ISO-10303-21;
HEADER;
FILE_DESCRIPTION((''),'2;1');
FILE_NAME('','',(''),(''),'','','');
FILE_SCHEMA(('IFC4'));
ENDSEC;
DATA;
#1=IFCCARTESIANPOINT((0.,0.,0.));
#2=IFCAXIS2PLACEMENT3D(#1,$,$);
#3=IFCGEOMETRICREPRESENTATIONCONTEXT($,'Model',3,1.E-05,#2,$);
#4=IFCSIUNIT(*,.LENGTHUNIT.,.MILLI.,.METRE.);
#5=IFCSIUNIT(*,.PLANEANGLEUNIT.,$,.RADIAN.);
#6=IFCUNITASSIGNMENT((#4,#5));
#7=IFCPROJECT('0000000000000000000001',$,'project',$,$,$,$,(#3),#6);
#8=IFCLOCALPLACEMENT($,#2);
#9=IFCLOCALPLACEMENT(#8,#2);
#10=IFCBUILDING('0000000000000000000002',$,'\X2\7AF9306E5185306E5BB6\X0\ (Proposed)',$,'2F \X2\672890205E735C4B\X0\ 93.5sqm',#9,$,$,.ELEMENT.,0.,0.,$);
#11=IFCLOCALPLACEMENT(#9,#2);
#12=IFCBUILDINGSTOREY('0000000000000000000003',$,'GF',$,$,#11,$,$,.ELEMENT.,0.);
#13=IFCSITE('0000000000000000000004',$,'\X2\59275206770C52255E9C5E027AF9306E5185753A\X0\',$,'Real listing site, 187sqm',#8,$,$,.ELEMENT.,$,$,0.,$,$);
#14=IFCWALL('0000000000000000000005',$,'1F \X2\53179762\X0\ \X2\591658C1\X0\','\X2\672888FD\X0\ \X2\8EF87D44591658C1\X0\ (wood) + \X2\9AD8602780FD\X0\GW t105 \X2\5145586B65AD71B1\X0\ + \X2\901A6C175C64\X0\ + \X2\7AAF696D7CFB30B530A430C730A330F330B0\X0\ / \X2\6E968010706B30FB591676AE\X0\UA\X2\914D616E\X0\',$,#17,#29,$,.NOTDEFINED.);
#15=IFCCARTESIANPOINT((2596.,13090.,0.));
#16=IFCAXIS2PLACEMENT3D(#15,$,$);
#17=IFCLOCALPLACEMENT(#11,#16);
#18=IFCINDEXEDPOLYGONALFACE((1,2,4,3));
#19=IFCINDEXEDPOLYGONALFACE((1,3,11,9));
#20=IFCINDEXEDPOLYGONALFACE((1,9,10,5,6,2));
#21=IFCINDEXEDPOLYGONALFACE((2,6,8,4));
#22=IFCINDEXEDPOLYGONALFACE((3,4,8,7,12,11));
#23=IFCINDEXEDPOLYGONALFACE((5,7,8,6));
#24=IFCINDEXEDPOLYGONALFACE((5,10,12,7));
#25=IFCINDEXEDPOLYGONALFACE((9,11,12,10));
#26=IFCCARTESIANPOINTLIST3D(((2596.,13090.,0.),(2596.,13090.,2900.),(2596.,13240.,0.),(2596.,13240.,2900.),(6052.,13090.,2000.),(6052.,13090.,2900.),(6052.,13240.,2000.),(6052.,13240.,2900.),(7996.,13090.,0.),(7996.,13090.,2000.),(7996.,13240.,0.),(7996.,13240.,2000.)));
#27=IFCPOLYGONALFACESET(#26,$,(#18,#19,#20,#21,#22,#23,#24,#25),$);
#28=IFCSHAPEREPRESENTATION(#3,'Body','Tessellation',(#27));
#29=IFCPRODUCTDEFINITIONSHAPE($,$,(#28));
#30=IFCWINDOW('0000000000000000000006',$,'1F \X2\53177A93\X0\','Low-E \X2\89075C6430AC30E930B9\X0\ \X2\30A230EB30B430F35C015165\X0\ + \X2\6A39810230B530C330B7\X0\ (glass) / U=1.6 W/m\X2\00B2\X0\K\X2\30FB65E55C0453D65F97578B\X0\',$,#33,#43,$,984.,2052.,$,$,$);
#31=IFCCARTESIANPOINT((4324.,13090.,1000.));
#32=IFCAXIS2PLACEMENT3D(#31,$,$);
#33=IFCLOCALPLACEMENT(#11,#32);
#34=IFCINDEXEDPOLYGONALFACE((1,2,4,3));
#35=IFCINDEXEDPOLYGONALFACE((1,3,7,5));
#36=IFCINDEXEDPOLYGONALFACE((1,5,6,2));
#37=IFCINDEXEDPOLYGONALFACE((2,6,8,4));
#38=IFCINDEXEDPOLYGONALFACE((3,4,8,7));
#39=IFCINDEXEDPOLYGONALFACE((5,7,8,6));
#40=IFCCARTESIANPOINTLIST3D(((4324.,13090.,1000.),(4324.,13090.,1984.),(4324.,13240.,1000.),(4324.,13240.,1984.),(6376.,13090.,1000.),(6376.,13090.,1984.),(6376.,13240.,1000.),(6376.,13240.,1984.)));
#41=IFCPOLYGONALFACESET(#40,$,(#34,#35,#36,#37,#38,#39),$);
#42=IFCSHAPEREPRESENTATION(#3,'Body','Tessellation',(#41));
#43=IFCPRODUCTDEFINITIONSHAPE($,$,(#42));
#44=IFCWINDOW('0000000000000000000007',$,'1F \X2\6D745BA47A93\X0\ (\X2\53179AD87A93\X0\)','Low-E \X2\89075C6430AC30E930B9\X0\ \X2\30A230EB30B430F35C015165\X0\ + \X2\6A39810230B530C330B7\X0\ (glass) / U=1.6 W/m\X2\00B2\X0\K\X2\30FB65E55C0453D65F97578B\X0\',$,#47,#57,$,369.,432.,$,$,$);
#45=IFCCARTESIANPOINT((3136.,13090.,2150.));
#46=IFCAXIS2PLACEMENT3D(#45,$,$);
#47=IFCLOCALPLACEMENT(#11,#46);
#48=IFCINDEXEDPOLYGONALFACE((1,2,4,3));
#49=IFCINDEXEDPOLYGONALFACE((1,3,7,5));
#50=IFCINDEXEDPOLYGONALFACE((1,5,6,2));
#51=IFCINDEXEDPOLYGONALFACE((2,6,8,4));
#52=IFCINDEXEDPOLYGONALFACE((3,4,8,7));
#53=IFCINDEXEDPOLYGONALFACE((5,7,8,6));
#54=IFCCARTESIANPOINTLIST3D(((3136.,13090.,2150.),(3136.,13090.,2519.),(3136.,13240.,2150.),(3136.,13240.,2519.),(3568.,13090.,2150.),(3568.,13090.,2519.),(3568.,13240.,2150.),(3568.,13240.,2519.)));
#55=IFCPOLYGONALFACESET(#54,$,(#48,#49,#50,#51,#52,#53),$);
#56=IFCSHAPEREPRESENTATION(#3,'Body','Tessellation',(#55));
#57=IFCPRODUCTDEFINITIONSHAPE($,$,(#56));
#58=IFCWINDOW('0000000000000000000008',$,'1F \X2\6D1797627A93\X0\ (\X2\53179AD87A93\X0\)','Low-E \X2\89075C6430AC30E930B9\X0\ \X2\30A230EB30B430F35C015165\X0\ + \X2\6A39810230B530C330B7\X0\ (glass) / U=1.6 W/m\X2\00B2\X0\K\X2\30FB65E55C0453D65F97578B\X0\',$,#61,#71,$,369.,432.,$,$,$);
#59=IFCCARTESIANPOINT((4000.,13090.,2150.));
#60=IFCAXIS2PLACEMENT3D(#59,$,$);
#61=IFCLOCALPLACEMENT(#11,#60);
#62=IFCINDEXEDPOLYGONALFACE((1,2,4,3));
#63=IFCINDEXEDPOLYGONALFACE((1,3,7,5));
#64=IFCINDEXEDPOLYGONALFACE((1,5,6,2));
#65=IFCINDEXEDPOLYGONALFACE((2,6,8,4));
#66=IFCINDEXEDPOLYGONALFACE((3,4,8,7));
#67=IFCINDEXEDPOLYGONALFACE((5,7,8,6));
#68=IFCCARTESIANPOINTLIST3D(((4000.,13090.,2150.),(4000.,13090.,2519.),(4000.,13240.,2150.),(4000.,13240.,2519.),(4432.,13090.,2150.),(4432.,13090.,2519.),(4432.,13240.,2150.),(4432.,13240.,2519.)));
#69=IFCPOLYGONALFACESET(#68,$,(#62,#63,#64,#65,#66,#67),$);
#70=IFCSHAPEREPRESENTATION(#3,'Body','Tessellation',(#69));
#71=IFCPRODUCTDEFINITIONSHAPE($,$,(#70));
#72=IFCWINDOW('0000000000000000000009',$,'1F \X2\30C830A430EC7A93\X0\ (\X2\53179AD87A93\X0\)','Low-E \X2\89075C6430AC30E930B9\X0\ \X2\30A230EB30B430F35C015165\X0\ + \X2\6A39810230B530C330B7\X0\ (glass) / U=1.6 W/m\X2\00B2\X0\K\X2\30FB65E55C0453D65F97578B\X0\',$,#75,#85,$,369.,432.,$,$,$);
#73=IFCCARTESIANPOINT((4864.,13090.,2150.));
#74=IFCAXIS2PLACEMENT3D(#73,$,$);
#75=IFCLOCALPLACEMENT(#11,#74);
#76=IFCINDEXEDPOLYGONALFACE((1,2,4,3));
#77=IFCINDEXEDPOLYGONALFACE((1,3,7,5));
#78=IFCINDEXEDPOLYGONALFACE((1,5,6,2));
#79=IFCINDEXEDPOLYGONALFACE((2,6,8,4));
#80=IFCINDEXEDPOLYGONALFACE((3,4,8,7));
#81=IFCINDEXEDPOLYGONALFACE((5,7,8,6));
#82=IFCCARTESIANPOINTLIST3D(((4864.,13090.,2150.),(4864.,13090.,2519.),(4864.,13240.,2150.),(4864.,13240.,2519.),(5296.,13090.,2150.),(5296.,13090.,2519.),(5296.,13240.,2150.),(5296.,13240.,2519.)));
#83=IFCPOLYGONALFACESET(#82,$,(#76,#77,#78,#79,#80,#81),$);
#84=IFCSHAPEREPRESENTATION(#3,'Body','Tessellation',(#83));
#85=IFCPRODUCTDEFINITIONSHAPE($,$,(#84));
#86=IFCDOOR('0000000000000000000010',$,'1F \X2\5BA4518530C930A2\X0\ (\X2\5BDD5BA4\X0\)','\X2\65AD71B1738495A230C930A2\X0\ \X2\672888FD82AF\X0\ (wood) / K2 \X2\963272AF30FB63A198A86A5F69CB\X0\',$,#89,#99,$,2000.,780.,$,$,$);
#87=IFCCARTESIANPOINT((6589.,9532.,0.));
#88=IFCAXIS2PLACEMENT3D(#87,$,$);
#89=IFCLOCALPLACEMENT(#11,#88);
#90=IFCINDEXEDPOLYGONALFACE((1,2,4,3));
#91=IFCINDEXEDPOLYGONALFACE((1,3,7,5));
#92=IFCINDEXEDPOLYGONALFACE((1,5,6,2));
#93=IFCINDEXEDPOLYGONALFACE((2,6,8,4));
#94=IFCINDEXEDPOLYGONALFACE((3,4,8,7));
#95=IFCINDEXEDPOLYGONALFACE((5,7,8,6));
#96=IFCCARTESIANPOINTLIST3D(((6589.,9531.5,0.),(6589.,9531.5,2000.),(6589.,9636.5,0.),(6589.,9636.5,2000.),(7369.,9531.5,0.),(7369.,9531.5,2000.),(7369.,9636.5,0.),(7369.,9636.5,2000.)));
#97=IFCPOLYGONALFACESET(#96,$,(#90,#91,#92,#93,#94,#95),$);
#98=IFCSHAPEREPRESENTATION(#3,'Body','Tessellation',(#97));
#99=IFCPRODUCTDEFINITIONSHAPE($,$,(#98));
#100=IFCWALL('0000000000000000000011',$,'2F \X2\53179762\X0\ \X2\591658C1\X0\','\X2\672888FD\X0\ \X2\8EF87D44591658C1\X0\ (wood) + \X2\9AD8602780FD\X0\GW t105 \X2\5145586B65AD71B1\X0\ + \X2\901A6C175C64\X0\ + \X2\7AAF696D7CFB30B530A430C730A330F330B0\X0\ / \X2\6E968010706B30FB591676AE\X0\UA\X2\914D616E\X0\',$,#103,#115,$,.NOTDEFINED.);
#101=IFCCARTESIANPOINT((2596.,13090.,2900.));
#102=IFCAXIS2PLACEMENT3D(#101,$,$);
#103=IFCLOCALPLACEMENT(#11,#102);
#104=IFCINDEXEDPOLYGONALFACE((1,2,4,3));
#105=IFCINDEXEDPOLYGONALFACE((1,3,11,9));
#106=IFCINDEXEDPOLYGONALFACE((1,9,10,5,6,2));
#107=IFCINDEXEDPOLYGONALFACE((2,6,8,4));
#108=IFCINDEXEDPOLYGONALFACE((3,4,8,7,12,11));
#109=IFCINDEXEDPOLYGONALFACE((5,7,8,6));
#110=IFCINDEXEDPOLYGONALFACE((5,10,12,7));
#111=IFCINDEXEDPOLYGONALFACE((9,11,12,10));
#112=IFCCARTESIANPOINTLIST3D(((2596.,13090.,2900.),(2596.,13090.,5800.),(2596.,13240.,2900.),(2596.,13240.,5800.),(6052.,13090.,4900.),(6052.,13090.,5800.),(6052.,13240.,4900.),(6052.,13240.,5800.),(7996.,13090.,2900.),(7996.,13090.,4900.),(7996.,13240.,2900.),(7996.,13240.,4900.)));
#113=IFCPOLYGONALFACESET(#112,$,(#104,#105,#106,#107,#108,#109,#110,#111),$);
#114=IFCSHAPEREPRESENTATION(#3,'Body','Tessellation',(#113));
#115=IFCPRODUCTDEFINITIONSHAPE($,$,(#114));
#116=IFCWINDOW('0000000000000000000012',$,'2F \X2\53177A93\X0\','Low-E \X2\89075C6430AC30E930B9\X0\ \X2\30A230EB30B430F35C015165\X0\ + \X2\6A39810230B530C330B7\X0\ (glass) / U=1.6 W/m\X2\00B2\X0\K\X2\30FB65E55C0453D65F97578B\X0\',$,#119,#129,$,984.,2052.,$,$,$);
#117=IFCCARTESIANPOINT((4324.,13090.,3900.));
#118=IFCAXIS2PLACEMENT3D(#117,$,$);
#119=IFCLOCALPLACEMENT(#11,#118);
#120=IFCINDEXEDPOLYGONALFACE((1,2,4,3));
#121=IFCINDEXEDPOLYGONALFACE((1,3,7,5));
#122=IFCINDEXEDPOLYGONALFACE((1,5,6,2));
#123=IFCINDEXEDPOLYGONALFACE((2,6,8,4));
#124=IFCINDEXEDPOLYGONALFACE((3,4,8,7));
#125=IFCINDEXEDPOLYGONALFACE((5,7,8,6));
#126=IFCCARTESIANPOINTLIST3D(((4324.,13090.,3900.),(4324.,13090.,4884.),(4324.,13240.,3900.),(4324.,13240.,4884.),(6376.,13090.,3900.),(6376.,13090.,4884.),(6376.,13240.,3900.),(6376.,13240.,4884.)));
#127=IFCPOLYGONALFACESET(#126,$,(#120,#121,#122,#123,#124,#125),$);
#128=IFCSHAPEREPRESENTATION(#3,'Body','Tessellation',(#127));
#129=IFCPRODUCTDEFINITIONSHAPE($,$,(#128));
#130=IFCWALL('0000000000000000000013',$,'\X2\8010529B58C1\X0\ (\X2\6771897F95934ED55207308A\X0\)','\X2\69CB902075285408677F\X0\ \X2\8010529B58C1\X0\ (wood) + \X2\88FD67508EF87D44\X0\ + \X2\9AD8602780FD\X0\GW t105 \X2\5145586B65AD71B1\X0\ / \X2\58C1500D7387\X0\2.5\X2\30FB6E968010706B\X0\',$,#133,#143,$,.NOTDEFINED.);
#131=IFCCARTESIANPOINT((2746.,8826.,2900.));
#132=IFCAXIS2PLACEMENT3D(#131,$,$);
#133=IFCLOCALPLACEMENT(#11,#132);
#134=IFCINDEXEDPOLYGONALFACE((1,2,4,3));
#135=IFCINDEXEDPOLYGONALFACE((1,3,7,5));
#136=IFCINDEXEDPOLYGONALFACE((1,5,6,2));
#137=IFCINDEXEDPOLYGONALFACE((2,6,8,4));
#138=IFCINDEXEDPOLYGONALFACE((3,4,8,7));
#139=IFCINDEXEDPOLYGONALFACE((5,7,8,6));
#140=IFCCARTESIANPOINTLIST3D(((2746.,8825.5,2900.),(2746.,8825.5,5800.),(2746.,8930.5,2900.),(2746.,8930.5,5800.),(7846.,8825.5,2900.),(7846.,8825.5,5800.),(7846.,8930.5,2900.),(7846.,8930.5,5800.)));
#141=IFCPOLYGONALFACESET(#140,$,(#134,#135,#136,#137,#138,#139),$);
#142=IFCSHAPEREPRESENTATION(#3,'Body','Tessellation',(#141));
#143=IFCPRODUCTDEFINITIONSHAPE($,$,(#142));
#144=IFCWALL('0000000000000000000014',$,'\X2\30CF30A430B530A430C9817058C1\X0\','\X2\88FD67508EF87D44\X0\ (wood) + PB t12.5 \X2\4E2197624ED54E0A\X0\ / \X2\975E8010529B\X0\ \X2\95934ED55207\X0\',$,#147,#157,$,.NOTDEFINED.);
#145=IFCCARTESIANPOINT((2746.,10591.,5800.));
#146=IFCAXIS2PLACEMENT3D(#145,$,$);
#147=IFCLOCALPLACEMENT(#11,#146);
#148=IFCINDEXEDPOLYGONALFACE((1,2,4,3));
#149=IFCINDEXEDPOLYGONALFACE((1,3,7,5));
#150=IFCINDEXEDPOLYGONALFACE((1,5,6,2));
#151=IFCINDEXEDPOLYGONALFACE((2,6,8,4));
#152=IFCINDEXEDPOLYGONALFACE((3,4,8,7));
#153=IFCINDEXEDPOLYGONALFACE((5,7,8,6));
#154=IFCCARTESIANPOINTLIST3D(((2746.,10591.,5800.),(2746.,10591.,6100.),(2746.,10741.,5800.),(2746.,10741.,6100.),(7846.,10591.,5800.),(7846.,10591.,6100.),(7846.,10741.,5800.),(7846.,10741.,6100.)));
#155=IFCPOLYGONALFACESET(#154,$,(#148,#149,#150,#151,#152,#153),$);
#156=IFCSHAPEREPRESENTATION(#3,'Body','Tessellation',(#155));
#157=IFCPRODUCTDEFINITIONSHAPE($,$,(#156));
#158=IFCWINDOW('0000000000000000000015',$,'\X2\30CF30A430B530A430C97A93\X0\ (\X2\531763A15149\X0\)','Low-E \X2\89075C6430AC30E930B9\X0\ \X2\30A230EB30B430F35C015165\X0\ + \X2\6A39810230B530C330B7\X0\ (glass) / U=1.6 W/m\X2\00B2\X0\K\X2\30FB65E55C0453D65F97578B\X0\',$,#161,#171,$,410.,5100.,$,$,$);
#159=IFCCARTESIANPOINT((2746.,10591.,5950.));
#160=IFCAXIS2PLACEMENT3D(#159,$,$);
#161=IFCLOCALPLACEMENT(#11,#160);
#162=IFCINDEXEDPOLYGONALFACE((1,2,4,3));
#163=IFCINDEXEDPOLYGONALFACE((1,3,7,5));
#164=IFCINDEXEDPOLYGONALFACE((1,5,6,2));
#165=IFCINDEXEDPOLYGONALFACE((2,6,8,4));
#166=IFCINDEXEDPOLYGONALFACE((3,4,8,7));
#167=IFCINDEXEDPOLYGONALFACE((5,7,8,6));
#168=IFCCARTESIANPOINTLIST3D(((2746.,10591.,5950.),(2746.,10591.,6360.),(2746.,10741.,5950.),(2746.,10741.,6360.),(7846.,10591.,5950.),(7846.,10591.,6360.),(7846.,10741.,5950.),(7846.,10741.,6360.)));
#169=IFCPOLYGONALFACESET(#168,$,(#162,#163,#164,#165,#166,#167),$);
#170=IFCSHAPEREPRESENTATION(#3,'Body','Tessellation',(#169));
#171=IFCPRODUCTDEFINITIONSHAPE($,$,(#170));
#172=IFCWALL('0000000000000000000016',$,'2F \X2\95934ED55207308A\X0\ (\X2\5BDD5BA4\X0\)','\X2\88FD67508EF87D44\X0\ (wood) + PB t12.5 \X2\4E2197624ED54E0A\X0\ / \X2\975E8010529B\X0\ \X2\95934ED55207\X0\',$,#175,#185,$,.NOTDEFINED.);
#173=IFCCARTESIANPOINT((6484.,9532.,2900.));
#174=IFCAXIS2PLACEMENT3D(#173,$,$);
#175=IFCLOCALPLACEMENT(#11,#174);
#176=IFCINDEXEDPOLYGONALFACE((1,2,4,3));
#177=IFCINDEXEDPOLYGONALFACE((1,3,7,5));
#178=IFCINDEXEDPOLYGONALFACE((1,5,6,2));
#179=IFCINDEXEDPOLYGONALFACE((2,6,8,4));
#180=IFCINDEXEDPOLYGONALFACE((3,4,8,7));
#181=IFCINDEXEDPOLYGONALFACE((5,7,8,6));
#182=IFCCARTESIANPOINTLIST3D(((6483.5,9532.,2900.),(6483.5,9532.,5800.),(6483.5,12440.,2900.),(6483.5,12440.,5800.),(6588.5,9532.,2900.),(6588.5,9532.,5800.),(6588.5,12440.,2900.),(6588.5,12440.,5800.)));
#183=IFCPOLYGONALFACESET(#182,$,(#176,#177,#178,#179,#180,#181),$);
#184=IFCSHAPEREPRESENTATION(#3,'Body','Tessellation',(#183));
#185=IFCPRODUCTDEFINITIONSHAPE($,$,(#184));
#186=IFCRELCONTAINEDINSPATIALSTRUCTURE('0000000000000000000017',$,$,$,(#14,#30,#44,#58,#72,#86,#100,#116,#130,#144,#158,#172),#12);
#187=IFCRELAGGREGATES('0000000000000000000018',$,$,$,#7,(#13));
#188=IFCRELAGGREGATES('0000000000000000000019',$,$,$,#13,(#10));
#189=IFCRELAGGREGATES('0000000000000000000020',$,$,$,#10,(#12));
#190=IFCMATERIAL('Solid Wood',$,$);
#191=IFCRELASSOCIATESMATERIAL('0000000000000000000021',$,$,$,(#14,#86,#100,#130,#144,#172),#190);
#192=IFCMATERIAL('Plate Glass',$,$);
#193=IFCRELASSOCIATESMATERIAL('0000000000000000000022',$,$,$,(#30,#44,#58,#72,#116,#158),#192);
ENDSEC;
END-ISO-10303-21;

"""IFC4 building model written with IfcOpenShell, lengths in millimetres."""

from ifc_helpers import new_model, si_unit, frame, frame_2d, origin, place, context, project, spatial, rectangle, extrude, material, element, fill, save


model = new_model("IFC4")

# Units and contexts
model_context = context("Model", 3, precision=1e-05, world=origin())
ifc_project = project(units=[si_unit("LENGTHUNIT", "METRE", prefix="MILLI"), si_unit("PLANEANGLEUNIT", "RADIAN")], contexts=[model_context])

# Site, building, storey
site_placement = place(None, origin())
site = spatial("IfcSite", under=ifc_project, at=site_placement, Name="大分県別府市竹の内町", ObjectType="Real listing site, 187sqm", CompositionType="ELEMENT", RefElevation=0.0)
building_placement = place(site_placement, origin())
building = spatial("IfcBuilding", under=site, at=building_placement, Name="竹の内の家 (Proposed)", ObjectType="2F 木造平屋 93.5sqm", CompositionType="ELEMENT", ElevationOfRefHeight=0.0, ElevationOfTerrain=0.0)
storey_placement = place(building_placement, origin())
storey = spatial("IfcBuildingStorey", under=building, at=storey_placement, Name="GF", CompositionType="ELEMENT", Elevation=0.0)

# Wall, openings, windows
ifc_material_1 = material(Name="Solid Wood")
wall_1_placement = place(storey_placement, frame((2596.0, 13090.0, 0.0)))
wall_1 = element("IfcWall", 1, at=wall_1_placement, inside=storey, material=ifc_material_1, Name="1F 北面 外壁", Description="木製 軸組外壁 (wood) + 高性能GW t105 充填断熱 + 通気層 + 窯業系サイディング / 準耐火・外皮UA配慮", PredefinedType="NOTDEFINED", context=model_context, shape_type="SweptSolid", body=[
    extrude(rectangle(XDim=5400.0, YDim=150.0, at=frame_2d((2700.0, 75.0))), frame((2596.0, 13090.0, 0.0)), (0.0, 0.0, 1.0), 2900.0),
])
opening_1_placement = place(storey_placement, frame((4324.0, 13090.0, 1000.0)))
opening_1 = element("IfcOpeningElement", 2, at=opening_1_placement, cuts=wall_1, PredefinedType="NOTDEFINED", context=model_context, shape_type="SweptSolid", body=[
    extrude(rectangle(XDim=2052.0, YDim=150.0, at=frame_2d((1026.0, 75.0))), frame((4324.0, 13090.0, 1000.0)), (0.0, 0.0, 1.0), 984.0),
])
opening_2_placement = place(storey_placement, frame((3136.0, 13090.0, 2150.0)))
opening_2 = element("IfcOpeningElement", 3, at=opening_2_placement, cuts=wall_1, PredefinedType="NOTDEFINED", context=model_context, shape_type="SweptSolid", body=[
    extrude(rectangle(XDim=432.0, YDim=150.0, at=frame_2d((216.0, 75.0))), frame((3136.0, 13090.0, 2150.0)), (0.0, 0.0, 1.0), 369.0),
])
opening_3_placement = place(storey_placement, frame((4000.0, 13090.0, 2150.0)))
opening_3 = element("IfcOpeningElement", 4, at=opening_3_placement, cuts=wall_1, PredefinedType="NOTDEFINED", context=model_context, shape_type="SweptSolid", body=[
    extrude(rectangle(XDim=432.0, YDim=150.0, at=frame_2d((216.0, 75.0))), frame((4000.0, 13090.0, 2150.0)), (0.0, 0.0, 1.0), 369.0),
])
opening_4_placement = place(storey_placement, frame((4864.0, 13090.0, 2150.0)))
opening_4 = element("IfcOpeningElement", 5, at=opening_4_placement, cuts=wall_1, PredefinedType="NOTDEFINED", context=model_context, shape_type="SweptSolid", body=[
    extrude(rectangle(XDim=432.0, YDim=150.0, at=frame_2d((216.0, 75.0))), frame((4864.0, 13090.0, 2150.0)), (0.0, 0.0, 1.0), 369.0),
])
ifc_material_2 = material(Name="Plate Glass")
window_1_placement = place(storey_placement, frame((4324.0, 13090.0, 1000.0)))
window_1 = element("IfcWindow", 6, at=window_1_placement, inside=storey, material=ifc_material_2, Name="1F 北窓", Description="Low-E 複層ガラス アルゴン封入 + 樹脂サッシ (glass) / U=1.6 W/m²K・日射取得型", OverallHeight=984.0, OverallWidth=2052.0, context=model_context, shape_type="SweptSolid", body=[
    extrude(rectangle(XDim=2052.0, YDim=150.0, at=frame_2d((1026.0, 75.0))), frame((4324.0, 13090.0, 1000.0)), (0.0, 0.0, 1.0), 984.0),
])
fill(opening_1, window_1)
window_2_placement = place(storey_placement, frame((3136.0, 13090.0, 2150.0)))
window_2 = element("IfcWindow", 7, at=window_2_placement, inside=storey, material=ifc_material_2, Name="1F 浴室窓 (北高窓)", Description="Low-E 複層ガラス アルゴン封入 + 樹脂サッシ (glass) / U=1.6 W/m²K・日射取得型", OverallHeight=369.0, OverallWidth=432.0, context=model_context, shape_type="SweptSolid", body=[
    extrude(rectangle(XDim=432.0, YDim=150.0, at=frame_2d((216.0, 75.0))), frame((3136.0, 13090.0, 2150.0)), (0.0, 0.0, 1.0), 369.0),
])
fill(opening_2, window_2)
window_3_placement = place(storey_placement, frame((4000.0, 13090.0, 2150.0)))
window_3 = element("IfcWindow", 8, at=window_3_placement, inside=storey, material=ifc_material_2, Name="1F 洗面窓 (北高窓)", Description="Low-E 複層ガラス アルゴン封入 + 樹脂サッシ (glass) / U=1.6 W/m²K・日射取得型", OverallHeight=369.0, OverallWidth=432.0, context=model_context, shape_type="SweptSolid", body=[
    extrude(rectangle(XDim=432.0, YDim=150.0, at=frame_2d((216.0, 75.0))), frame((4000.0, 13090.0, 2150.0)), (0.0, 0.0, 1.0), 369.0),
])
fill(opening_3, window_3)
window_4_placement = place(storey_placement, frame((4864.0, 13090.0, 2150.0)))
window_4 = element("IfcWindow", 9, at=window_4_placement, inside=storey, material=ifc_material_2, Name="1F トイレ窓 (北高窓)", Description="Low-E 複層ガラス アルゴン封入 + 樹脂サッシ (glass) / U=1.6 W/m²K・日射取得型", OverallHeight=369.0, OverallWidth=432.0, context=model_context, shape_type="SweptSolid", body=[
    extrude(rectangle(XDim=432.0, YDim=150.0, at=frame_2d((216.0, 75.0))), frame((4864.0, 13090.0, 2150.0)), (0.0, 0.0, 1.0), 369.0),
])
fill(opening_4, window_4)

# Door
door_1_placement = place(storey_placement, frame((6589.0, 9532.0, 0.0)))
element("IfcDoor", 10, at=door_1_placement, inside=storey, material=ifc_material_1, Name="1F 室内ドア (寝室)", Description="断熱玄関ドア 木製芯 (wood) / K2 防犯・採風機構", OverallHeight=2000.0, OverallWidth=780.0, context=model_context, shape_type="SweptSolid", body=[
    extrude(rectangle(XDim=780.0, YDim=105.0, at=frame_2d((390.0, 52.0))), frame((6589.0, 9532.0, 0.0)), (0.0, 0.0, 1.0), 2000.0),
])

# Wall, opening, window
wall_2_placement = place(storey_placement, frame((2596.0, 13090.0, 2900.0)))
wall_2 = element("IfcWall", 11, at=wall_2_placement, inside=storey, material=ifc_material_1, Name="2F 北面 外壁", Description="木製 軸組外壁 (wood) + 高性能GW t105 充填断熱 + 通気層 + 窯業系サイディング / 準耐火・外皮UA配慮", PredefinedType="NOTDEFINED", context=model_context, shape_type="SweptSolid", body=[
    extrude(rectangle(XDim=5400.0, YDim=150.0, at=frame_2d((2700.0, 75.0))), frame((2596.0, 13090.0, 2900.0)), (0.0, 0.0, 1.0), 2900.0),
])
opening_5_placement = place(storey_placement, frame((4324.0, 13090.0, 3900.0)))
opening_5 = element("IfcOpeningElement", 12, at=opening_5_placement, cuts=wall_2, PredefinedType="NOTDEFINED", context=model_context, shape_type="SweptSolid", body=[
    extrude(rectangle(XDim=2052.0, YDim=150.0, at=frame_2d((1026.0, 75.0))), frame((4324.0, 13090.0, 3900.0)), (0.0, 0.0, 1.0), 984.0),
])
window_5_placement = place(storey_placement, frame((4324.0, 13090.0, 3900.0)))
window_5 = element("IfcWindow", 13, at=window_5_placement, inside=storey, material=ifc_material_2, Name="2F 北窓", Description="Low-E 複層ガラス アルゴン封入 + 樹脂サッシ (glass) / U=1.6 W/m²K・日射取得型", OverallHeight=984.0, OverallWidth=2052.0, context=model_context, shape_type="SweptSolid", body=[
    extrude(rectangle(XDim=2052.0, YDim=150.0, at=frame_2d((1026.0, 75.0))), frame((4324.0, 13090.0, 3900.0)), (0.0, 0.0, 1.0), 984.0),
])
fill(opening_5, window_5)

# Wall
wall_3_placement = place(storey_placement, frame((2746.0, 8826.0, 2900.0)))
element("IfcWall", 14, at=wall_3_placement, inside=storey, material=ifc_material_1, Name="耐力壁 (東西間仕切り)", Description="構造用合板 耐力壁 (wood) + 製材軸組 + 高性能GW t105 充填断熱 / 壁倍率2.5・準耐火", PredefinedType="NOTDEFINED", context=model_context, shape_type="SweptSolid", body=[
    extrude(rectangle(XDim=5100.0, YDim=105.0, at=frame_2d((2550.0, 52.0))), frame((2746.0, 8826.0, 2900.0)), (0.0, 0.0, 1.0), 2900.0),
])

# Wall, opening, window
wall_4_placement = place(storey_placement, frame((2746.0, 10591.0, 5800.0)))
wall_4 = element("IfcWall", 15, at=wall_4_placement, inside=storey, material=ifc_material_1, Name="ハイサイド腰壁", Description="製材軸組 (wood) + PB t12.5 両面仕上 / 非耐力 間仕切", PredefinedType="NOTDEFINED", context=model_context, shape_type="SweptSolid", body=[
    extrude(rectangle(XDim=5100.0, YDim=150.0, at=frame_2d((2550.0, 75.0))), frame((2746.0, 10591.0, 5800.0)), (0.0, 0.0, 1.0), 700.0),
])
opening_6_placement = place(storey_placement, frame((2746.0, 10591.0, 5950.0)))
opening_6 = element("IfcOpeningElement", 16, at=opening_6_placement, cuts=wall_4, PredefinedType="NOTDEFINED", context=model_context, shape_type="SweptSolid", body=[
    extrude(rectangle(XDim=5100.0, YDim=150.0, at=frame_2d((2550.0, 75.0))), frame((2746.0, 10591.0, 5950.0)), (0.0, 0.0, 1.0), 410.0),
])
window_6_placement = place(storey_placement, frame((2746.0, 10591.0, 5950.0)))
window_6 = element("IfcWindow", 17, at=window_6_placement, inside=storey, material=ifc_material_2, Name="ハイサイド窓 (北採光)", Description="Low-E 複層ガラス アルゴン封入 + 樹脂サッシ (glass) / U=1.6 W/m²K・日射取得型", OverallHeight=410.0, OverallWidth=5100.0, context=model_context, shape_type="SweptSolid", body=[
    extrude(rectangle(XDim=5100.0, YDim=150.0, at=frame_2d((2550.0, 75.0))), frame((2746.0, 10591.0, 5950.0)), (0.0, 0.0, 1.0), 410.0),
])
fill(opening_6, window_6)

# Wall
wall_5_placement = place(storey_placement, frame((6484.0, 9532.0, 2900.0)))
element("IfcWall", 18, at=wall_5_placement, inside=storey, material=ifc_material_1, Name="2F 間仕切り (寝室)", Description="製材軸組 (wood) + PB t12.5 両面仕上 / 非耐力 間仕切", PredefinedType="NOTDEFINED", context=model_context, shape_type="SweptSolid", body=[
    extrude(rectangle(XDim=105.0, YDim=2908.0, at=frame_2d((52.0, 1454.0))), frame((6484.0, 9532.0, 2900.0)), (0.0, 0.0, 1.0), 2900.0),
])

save(model, "model.ifc")
